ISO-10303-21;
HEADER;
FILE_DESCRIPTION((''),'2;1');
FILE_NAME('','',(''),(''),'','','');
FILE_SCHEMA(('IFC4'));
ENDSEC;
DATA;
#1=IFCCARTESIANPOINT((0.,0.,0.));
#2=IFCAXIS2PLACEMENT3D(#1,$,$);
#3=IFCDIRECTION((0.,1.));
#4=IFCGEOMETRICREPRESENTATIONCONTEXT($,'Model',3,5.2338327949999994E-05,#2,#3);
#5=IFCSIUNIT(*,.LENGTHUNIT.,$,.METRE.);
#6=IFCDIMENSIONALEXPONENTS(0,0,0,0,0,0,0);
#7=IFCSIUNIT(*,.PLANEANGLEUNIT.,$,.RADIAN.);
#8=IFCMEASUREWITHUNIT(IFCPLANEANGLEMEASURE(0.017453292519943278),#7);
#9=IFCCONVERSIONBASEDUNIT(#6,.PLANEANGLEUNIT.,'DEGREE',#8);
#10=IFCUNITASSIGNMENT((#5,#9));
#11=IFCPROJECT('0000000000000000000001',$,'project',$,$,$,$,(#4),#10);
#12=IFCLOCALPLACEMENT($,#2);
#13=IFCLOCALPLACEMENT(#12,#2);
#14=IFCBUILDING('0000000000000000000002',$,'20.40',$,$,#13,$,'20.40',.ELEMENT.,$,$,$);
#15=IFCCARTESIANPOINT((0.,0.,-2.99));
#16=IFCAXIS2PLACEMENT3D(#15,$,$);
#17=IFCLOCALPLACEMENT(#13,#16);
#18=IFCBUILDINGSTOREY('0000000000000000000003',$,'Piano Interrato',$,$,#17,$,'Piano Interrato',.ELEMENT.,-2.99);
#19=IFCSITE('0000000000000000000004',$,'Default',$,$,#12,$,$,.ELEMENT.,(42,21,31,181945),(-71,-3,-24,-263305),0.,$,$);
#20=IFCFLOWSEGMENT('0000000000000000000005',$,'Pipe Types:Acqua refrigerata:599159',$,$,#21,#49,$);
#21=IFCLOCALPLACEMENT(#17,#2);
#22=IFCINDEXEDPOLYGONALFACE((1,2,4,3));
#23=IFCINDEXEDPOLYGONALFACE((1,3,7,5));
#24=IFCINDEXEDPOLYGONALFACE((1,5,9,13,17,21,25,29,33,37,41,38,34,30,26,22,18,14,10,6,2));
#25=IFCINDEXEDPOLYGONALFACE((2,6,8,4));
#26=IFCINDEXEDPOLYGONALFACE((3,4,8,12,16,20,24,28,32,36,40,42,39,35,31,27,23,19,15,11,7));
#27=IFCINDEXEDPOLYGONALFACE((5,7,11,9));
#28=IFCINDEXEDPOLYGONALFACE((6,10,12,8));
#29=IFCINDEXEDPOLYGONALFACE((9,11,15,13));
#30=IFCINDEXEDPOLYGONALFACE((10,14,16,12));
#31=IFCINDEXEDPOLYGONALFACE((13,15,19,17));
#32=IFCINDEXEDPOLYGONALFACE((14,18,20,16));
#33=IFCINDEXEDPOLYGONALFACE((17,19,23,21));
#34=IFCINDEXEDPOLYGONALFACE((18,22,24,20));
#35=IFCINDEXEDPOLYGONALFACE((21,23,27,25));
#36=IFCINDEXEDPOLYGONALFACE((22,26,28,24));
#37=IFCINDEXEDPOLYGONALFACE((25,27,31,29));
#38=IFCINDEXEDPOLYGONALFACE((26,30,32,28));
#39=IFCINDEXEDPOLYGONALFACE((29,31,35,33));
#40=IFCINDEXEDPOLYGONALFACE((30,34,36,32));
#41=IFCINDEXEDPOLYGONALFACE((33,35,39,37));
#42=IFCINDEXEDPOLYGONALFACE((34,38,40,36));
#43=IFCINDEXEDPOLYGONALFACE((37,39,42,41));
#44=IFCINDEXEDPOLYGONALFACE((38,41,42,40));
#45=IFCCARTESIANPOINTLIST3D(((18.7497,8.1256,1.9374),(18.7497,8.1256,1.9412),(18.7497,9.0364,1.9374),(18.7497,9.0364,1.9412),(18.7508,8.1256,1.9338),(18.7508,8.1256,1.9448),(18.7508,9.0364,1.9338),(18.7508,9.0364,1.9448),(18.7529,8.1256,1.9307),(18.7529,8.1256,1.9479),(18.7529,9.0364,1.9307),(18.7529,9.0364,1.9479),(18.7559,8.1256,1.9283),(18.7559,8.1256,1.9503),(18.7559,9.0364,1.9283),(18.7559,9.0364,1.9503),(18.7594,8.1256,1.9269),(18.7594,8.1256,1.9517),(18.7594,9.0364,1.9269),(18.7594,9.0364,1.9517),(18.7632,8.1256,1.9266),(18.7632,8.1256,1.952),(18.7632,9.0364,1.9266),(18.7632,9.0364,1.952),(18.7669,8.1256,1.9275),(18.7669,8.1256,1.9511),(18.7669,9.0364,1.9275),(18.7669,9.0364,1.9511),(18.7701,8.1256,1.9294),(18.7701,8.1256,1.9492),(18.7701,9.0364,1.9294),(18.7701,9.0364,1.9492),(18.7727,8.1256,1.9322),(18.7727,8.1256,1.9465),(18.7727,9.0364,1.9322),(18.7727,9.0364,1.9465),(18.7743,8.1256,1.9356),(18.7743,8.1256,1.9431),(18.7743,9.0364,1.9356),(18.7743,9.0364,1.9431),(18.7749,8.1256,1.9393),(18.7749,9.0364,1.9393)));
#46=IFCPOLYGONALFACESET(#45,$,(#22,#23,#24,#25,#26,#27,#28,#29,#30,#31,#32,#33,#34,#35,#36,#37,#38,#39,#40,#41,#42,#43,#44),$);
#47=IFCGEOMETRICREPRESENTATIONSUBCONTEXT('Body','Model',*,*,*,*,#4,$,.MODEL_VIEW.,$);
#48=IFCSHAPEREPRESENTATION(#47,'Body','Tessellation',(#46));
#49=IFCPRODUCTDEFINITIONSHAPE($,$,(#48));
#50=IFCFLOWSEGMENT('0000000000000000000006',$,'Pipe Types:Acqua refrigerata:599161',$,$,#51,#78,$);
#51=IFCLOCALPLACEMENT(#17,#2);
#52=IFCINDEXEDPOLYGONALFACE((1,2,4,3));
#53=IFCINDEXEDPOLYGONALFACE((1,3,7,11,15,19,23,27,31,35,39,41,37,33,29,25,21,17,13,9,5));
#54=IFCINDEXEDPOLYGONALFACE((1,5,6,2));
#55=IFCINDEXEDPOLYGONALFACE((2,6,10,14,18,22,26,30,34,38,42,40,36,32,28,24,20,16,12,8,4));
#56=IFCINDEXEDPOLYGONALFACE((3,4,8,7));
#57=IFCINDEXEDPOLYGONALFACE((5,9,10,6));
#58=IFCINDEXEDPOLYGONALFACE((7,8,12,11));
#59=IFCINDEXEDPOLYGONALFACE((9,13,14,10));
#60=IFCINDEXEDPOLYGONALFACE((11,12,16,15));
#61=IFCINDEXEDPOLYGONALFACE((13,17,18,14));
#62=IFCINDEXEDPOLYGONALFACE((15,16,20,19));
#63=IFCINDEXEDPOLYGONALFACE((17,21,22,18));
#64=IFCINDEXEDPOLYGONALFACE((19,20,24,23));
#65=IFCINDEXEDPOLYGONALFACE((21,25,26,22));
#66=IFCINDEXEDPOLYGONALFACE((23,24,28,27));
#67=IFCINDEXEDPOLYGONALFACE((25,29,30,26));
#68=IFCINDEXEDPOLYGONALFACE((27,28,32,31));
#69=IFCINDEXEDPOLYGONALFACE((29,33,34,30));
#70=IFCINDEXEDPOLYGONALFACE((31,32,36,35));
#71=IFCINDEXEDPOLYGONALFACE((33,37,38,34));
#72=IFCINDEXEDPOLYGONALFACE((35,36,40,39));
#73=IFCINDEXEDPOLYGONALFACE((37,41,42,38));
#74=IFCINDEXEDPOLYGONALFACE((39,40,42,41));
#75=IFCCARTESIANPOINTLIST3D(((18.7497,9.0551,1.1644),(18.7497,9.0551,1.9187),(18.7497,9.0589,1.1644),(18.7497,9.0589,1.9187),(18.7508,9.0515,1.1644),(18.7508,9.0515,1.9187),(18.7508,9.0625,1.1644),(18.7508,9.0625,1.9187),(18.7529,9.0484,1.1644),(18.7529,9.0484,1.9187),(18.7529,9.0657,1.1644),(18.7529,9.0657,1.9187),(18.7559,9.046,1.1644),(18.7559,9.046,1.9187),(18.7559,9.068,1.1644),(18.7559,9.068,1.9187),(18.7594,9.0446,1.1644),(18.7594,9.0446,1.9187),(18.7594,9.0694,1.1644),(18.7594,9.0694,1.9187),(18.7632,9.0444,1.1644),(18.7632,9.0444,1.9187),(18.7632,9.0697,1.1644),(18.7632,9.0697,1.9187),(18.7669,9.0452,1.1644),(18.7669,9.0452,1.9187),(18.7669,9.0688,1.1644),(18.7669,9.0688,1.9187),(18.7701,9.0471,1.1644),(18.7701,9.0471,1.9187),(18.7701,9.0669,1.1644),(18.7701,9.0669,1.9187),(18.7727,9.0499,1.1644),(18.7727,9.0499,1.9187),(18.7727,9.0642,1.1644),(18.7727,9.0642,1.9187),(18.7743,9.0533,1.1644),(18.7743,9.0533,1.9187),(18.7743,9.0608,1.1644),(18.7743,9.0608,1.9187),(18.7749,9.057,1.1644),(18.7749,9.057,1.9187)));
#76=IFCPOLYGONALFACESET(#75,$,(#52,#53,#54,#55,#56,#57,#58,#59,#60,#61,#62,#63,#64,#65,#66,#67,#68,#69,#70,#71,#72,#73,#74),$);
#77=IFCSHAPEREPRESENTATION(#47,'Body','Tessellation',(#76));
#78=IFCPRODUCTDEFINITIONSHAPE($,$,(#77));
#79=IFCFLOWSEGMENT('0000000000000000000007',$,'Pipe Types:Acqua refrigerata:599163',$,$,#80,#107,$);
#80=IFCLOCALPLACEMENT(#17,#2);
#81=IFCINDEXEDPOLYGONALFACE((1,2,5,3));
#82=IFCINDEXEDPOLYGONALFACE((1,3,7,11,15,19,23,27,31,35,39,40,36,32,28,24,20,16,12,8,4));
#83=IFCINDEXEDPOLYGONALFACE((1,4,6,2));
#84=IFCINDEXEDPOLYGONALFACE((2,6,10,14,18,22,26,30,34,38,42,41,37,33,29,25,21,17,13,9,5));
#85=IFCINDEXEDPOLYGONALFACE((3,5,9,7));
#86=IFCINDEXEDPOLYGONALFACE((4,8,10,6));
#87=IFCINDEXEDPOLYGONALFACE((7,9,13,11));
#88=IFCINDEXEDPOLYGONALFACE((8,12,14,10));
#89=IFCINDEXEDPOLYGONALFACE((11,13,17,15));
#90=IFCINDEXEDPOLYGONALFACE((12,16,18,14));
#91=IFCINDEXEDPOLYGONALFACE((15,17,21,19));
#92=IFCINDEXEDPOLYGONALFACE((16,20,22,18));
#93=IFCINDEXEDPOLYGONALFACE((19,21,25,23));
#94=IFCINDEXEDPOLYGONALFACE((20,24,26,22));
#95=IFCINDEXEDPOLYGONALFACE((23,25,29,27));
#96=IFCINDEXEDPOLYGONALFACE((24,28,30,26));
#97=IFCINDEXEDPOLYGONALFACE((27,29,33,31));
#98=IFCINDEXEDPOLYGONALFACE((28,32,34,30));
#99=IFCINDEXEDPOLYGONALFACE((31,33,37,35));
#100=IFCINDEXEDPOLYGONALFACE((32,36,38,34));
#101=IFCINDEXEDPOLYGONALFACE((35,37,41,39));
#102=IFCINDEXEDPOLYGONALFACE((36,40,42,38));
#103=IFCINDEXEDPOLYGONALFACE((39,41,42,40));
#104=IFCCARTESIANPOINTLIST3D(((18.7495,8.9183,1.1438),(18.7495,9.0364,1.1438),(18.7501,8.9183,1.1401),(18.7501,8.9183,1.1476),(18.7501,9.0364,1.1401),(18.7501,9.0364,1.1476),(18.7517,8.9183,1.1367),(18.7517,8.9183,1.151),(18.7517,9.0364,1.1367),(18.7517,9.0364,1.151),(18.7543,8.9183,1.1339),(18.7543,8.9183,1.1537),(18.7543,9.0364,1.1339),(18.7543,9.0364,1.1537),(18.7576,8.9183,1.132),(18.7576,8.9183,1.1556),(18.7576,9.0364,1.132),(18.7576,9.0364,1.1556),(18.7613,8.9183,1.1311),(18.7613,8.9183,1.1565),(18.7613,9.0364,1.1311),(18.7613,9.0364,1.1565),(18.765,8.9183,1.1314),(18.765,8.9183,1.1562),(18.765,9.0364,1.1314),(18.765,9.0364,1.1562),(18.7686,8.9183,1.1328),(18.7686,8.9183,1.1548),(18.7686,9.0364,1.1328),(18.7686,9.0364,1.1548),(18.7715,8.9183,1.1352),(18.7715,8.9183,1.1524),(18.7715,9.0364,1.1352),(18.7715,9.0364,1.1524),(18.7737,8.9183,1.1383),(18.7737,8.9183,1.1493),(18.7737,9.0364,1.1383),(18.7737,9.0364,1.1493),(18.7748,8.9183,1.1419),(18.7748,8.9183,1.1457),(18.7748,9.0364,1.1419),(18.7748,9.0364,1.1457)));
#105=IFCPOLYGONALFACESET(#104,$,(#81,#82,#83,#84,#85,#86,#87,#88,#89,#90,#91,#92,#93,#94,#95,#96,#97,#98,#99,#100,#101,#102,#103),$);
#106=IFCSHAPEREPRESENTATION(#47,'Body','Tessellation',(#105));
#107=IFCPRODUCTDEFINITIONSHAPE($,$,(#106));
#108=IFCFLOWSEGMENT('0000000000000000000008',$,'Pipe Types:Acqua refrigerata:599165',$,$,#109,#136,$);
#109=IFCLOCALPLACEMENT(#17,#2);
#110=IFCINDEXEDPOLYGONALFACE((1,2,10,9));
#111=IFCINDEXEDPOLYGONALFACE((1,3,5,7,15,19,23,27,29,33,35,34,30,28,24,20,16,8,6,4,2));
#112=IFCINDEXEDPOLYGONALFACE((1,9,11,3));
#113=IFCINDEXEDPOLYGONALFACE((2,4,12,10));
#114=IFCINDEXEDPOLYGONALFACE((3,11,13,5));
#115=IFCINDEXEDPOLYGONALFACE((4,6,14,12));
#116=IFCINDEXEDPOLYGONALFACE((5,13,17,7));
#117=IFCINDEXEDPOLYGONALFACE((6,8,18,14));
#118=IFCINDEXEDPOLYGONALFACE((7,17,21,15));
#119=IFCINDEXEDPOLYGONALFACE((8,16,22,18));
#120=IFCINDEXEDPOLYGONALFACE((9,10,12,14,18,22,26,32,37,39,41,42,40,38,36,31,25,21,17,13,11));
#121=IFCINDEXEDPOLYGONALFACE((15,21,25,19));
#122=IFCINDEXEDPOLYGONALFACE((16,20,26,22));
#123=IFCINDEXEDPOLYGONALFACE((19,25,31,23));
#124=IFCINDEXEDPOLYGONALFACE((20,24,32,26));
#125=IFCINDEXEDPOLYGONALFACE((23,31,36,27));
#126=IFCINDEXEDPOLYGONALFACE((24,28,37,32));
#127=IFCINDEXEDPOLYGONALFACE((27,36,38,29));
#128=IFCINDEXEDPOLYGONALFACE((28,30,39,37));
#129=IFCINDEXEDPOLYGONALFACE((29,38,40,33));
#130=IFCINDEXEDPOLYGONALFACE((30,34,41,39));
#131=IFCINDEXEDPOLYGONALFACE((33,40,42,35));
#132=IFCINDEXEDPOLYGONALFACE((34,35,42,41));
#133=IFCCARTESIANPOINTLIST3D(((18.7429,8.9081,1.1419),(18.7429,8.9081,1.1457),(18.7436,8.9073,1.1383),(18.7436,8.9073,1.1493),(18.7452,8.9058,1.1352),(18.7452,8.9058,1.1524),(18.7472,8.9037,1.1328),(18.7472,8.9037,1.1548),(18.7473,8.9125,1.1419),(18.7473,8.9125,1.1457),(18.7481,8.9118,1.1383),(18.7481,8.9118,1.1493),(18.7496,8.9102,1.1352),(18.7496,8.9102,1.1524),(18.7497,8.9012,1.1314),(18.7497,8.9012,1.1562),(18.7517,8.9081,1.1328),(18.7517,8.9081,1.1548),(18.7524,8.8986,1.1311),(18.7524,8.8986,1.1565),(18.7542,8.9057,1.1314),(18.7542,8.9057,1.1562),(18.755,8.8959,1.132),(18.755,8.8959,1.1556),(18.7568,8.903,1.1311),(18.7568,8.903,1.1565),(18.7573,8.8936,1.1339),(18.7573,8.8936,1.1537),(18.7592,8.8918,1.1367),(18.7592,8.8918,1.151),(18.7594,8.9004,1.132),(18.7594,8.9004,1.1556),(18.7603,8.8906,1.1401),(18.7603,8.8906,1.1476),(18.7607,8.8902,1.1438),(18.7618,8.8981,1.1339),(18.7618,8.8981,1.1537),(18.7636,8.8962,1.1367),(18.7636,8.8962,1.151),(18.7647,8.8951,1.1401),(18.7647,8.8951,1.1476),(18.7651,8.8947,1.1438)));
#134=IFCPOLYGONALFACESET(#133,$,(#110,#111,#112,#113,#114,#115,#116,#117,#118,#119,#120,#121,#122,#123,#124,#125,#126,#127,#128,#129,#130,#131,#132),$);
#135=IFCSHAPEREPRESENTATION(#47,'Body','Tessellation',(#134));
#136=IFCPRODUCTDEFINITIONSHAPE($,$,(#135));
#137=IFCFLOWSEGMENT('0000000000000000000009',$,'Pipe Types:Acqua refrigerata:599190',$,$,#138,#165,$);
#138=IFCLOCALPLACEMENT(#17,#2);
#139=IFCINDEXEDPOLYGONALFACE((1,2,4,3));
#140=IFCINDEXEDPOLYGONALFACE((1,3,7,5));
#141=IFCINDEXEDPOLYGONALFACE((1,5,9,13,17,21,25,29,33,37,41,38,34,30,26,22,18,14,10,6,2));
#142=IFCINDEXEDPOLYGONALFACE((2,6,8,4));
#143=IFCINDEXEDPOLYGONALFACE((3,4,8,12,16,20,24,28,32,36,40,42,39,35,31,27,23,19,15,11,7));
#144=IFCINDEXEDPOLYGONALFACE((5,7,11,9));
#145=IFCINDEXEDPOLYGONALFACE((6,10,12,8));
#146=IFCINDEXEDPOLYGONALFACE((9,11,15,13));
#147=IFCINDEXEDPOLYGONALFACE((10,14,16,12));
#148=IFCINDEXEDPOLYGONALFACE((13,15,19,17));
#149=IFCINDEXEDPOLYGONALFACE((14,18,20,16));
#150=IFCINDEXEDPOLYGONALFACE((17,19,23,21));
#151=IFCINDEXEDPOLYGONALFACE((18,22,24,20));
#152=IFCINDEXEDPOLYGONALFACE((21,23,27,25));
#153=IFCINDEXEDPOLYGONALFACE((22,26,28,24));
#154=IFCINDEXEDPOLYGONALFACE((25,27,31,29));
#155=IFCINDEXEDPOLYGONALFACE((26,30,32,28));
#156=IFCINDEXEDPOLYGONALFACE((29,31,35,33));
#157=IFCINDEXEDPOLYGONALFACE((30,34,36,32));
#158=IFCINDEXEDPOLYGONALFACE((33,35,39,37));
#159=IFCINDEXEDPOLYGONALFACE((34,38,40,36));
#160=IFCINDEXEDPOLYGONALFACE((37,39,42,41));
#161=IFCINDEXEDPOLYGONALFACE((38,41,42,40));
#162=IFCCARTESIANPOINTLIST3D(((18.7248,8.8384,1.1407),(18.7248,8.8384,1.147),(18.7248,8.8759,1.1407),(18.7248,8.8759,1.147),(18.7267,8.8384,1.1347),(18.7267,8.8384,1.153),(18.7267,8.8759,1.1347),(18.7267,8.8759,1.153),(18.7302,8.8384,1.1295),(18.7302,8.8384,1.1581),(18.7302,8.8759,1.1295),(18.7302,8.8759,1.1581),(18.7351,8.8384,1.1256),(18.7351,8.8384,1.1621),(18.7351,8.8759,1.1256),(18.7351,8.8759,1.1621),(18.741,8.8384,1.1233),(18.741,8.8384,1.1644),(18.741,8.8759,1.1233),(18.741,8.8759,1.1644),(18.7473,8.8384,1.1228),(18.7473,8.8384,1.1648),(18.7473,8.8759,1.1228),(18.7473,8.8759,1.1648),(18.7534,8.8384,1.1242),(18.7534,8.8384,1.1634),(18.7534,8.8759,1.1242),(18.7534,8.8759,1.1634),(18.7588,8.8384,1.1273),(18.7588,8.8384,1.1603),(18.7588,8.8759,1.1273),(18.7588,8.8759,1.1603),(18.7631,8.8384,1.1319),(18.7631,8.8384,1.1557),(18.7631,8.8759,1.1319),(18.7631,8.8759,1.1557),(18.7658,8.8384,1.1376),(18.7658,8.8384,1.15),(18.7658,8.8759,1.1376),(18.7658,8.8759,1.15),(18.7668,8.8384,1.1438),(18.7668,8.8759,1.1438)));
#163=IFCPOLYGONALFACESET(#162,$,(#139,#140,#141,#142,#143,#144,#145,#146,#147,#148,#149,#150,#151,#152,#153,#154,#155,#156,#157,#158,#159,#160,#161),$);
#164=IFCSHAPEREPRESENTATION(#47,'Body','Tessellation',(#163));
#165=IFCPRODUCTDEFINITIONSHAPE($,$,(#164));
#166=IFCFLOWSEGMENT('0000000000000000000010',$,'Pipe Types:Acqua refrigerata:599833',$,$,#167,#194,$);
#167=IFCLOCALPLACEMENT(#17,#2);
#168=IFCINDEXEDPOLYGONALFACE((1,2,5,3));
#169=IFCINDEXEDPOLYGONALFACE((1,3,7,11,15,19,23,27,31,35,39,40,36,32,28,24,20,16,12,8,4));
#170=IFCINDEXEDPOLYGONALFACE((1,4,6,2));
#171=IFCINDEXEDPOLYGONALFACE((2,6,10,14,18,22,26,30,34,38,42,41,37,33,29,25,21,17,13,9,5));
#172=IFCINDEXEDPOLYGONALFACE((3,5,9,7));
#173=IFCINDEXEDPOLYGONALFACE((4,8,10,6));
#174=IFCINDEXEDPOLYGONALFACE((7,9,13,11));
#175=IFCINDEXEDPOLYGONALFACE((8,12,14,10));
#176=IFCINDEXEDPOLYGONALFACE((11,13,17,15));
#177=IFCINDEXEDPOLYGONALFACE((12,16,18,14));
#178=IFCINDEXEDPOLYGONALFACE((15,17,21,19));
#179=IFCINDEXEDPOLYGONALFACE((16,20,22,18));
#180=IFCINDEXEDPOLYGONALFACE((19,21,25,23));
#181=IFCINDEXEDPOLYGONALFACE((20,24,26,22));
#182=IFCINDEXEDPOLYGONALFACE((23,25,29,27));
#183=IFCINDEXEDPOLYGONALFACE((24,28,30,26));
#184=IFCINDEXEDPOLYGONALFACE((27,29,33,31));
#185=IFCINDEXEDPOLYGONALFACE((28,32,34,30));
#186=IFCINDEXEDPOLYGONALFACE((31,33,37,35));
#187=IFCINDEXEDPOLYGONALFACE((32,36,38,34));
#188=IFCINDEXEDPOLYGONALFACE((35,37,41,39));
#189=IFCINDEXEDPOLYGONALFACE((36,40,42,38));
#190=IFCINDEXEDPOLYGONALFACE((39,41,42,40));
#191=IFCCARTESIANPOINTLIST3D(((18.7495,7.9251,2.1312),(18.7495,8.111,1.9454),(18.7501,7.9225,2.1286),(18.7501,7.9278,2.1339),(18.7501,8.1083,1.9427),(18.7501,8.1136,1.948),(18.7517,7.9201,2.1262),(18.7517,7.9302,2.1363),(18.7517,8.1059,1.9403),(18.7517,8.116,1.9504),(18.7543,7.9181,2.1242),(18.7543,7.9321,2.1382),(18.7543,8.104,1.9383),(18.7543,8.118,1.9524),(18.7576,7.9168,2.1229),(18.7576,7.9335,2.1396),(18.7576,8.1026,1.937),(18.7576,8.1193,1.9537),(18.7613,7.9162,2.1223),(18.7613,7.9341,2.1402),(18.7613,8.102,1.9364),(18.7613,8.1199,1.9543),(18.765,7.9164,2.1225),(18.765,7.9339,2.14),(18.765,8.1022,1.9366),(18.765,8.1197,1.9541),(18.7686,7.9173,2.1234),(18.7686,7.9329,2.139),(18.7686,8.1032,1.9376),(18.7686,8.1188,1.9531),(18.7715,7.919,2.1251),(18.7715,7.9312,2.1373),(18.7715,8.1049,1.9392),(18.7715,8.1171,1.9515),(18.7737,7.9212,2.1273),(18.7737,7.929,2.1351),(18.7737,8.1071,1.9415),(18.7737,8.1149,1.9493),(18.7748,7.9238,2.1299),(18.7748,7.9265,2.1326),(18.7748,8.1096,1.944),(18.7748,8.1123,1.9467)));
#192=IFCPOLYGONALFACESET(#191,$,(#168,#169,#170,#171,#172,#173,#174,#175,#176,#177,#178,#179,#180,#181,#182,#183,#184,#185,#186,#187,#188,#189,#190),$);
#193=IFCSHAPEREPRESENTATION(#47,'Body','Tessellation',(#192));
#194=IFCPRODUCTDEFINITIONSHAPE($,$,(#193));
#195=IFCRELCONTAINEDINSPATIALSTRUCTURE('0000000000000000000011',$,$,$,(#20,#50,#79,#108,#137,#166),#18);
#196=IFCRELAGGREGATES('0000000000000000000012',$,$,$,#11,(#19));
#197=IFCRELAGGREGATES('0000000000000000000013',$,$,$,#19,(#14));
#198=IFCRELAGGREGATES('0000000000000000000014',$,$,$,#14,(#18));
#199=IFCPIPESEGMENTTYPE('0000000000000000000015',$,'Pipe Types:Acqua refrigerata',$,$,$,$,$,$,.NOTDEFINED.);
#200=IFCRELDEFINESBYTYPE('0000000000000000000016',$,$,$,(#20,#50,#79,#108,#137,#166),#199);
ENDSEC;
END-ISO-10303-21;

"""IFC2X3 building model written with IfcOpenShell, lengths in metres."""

from ifc_helpers import new_model, entity, si_unit, converted_unit, direction, frame, frame_2d, origin, origin_2d_with_axis, place, context, subcontext, project, spatial, circle, extrude, type_object, element, save


model = new_model("IFC2X3")

# Units and contexts
model_context = context("Model", 3, precision=5.2338327949999994e-05, world=origin(), true_north=direction((0.0, 1.0)))
body_context = subcontext(model_context, "Body", "Model", "MODEL_VIEW")
ifc_project = project(units=[si_unit("LENGTHUNIT", "METRE"), converted_unit("PLANEANGLEUNIT", "DEGREE", entity("IfcPlaneAngleMeasure", 0.017453292519943278), si_unit("PLANEANGLEUNIT", "RADIAN"), dimensions=[0, 0, 0, 0, 0, 0, 0])], contexts=[model_context])

# Site, building, storey
site_placement = place(None, origin())
site = spatial("IfcSite", under=ifc_project, at=site_placement, Name="Default", CompositionType="ELEMENT", RefLatitude=(42, 21, 31, 181945), RefLongitude=(-71, -3, -24, -263305), RefElevation=0.0)
building_placement = place(site_placement, origin())
building = spatial("IfcBuilding", under=site, at=building_placement, Name="20.40", LongName="20.40", CompositionType="ELEMENT")
storey_placement = place(building_placement, frame((0.0, 0.0, -2.99)))
storey = spatial("IfcBuildingStorey", under=building, at=storey_placement, Name="Piano Interrato", LongName="Piano Interrato", CompositionType="ELEMENT", Elevation=-2.99)

# Flow segments
pipe_segment_type_1 = type_object("IfcPipeSegmentType", Name="Pipe Types:Acqua refrigerata", PredefinedType="NOTDEFINED")
flow_segment_1_placement = place(storey_placement, origin())
element("IfcFlowSegment", 1, at=flow_segment_1_placement, inside=storey, type_object=pipe_segment_type_1, Name="Pipe Types:Acqua refrigerata:599159", context=body_context, shape_type="SweptSolid", body=[
    extrude(circle(Radius=0.0127, at=frame_2d((0.0, 0.0), x_axis=(1.0, 0.0))), frame((18.7622, 8.1256, 1.9393), z_axis=(0.0, 1.0, 0.0), x_axis=(1.0, 0.0, 0.0)), (0.0, 0.0, 1.0), 0.9108),
])
flow_segment_2_placement = place(storey_placement, origin())
element("IfcFlowSegment", 2, at=flow_segment_2_placement, inside=storey, type_object=pipe_segment_type_1, Name="Pipe Types:Acqua refrigerata:599161", context=body_context, shape_type="SweptSolid", body=[
    extrude(circle(Radius=0.0127, at=frame_2d((0.0, 0.0), x_axis=(1.0, 0.0))), frame((18.7622, 9.057, 1.1644)), (0.0, 0.0, 1.0), 0.7542),
])
flow_segment_3_placement = place(storey_placement, origin())
element("IfcFlowSegment", 3, at=flow_segment_3_placement, inside=storey, type_object=pipe_segment_type_1, Name="Pipe Types:Acqua refrigerata:599163", context=body_context, shape_type="SweptSolid", body=[
    extrude(circle(Radius=0.0127, at=origin_2d_with_axis()), frame((18.7622, 8.9183, 1.1438), z_axis=(0.0, 1.0, 0.0), x_axis=(-1.0, 0.0, 0.0)), (0.0, 0.0, 1.0), 0.1181),
])
flow_segment_4_placement = place(storey_placement, origin())
element("IfcFlowSegment", 4, at=flow_segment_4_placement, inside=storey, type_object=pipe_segment_type_1, Name="Pipe Types:Acqua refrigerata:599165", context=body_context, shape_type="SweptSolid", body=[
    extrude(circle(Radius=0.0127, at=frame_2d((0.0, 0.0), x_axis=(1.0, 0.0))), frame((18.7517, 8.8992, 1.1438), z_axis=(0.707113, 0.707101, 0.0), x_axis=(0.707101, -0.707113, 0.0)), (0.0, 0.0, 1.0), 0.0063),
])
flow_segment_5_placement = place(storey_placement, origin())
element("IfcFlowSegment", 5, at=flow_segment_5_placement, inside=storey, type_object=pipe_segment_type_1, Name="Pipe Types:Acqua refrigerata:599190", context=body_context, shape_type="SweptSolid", body=[
    extrude(circle(Radius=0.0211, at=origin_2d_with_axis()), frame((18.7457, 8.8384, 1.1438), z_axis=(0.0, 1.0, 0.0), x_axis=(1.0, 0.0, 0.0)), (0.0, 0.0, 1.0), 0.0375),
])
flow_segment_6_placement = place(storey_placement, origin())
element("IfcFlowSegment", 6, at=flow_segment_6_placement, inside=storey, type_object=pipe_segment_type_1, Name="Pipe Types:Acqua refrigerata:599833", context=body_context, shape_type="SweptSolid", body=[
    extrude(circle(Radius=0.0127, at=frame_2d((0.0, 0.0), x_axis=(1.0, 0.0))), frame((18.7622, 8.111, 1.9454), z_axis=(0.0, -0.707107, 0.707107), x_axis=(-1.0, 0.0, 0.0)), (0.0, 0.0, 1.0), 0.2628),
])

save(model, "model.ifc")
